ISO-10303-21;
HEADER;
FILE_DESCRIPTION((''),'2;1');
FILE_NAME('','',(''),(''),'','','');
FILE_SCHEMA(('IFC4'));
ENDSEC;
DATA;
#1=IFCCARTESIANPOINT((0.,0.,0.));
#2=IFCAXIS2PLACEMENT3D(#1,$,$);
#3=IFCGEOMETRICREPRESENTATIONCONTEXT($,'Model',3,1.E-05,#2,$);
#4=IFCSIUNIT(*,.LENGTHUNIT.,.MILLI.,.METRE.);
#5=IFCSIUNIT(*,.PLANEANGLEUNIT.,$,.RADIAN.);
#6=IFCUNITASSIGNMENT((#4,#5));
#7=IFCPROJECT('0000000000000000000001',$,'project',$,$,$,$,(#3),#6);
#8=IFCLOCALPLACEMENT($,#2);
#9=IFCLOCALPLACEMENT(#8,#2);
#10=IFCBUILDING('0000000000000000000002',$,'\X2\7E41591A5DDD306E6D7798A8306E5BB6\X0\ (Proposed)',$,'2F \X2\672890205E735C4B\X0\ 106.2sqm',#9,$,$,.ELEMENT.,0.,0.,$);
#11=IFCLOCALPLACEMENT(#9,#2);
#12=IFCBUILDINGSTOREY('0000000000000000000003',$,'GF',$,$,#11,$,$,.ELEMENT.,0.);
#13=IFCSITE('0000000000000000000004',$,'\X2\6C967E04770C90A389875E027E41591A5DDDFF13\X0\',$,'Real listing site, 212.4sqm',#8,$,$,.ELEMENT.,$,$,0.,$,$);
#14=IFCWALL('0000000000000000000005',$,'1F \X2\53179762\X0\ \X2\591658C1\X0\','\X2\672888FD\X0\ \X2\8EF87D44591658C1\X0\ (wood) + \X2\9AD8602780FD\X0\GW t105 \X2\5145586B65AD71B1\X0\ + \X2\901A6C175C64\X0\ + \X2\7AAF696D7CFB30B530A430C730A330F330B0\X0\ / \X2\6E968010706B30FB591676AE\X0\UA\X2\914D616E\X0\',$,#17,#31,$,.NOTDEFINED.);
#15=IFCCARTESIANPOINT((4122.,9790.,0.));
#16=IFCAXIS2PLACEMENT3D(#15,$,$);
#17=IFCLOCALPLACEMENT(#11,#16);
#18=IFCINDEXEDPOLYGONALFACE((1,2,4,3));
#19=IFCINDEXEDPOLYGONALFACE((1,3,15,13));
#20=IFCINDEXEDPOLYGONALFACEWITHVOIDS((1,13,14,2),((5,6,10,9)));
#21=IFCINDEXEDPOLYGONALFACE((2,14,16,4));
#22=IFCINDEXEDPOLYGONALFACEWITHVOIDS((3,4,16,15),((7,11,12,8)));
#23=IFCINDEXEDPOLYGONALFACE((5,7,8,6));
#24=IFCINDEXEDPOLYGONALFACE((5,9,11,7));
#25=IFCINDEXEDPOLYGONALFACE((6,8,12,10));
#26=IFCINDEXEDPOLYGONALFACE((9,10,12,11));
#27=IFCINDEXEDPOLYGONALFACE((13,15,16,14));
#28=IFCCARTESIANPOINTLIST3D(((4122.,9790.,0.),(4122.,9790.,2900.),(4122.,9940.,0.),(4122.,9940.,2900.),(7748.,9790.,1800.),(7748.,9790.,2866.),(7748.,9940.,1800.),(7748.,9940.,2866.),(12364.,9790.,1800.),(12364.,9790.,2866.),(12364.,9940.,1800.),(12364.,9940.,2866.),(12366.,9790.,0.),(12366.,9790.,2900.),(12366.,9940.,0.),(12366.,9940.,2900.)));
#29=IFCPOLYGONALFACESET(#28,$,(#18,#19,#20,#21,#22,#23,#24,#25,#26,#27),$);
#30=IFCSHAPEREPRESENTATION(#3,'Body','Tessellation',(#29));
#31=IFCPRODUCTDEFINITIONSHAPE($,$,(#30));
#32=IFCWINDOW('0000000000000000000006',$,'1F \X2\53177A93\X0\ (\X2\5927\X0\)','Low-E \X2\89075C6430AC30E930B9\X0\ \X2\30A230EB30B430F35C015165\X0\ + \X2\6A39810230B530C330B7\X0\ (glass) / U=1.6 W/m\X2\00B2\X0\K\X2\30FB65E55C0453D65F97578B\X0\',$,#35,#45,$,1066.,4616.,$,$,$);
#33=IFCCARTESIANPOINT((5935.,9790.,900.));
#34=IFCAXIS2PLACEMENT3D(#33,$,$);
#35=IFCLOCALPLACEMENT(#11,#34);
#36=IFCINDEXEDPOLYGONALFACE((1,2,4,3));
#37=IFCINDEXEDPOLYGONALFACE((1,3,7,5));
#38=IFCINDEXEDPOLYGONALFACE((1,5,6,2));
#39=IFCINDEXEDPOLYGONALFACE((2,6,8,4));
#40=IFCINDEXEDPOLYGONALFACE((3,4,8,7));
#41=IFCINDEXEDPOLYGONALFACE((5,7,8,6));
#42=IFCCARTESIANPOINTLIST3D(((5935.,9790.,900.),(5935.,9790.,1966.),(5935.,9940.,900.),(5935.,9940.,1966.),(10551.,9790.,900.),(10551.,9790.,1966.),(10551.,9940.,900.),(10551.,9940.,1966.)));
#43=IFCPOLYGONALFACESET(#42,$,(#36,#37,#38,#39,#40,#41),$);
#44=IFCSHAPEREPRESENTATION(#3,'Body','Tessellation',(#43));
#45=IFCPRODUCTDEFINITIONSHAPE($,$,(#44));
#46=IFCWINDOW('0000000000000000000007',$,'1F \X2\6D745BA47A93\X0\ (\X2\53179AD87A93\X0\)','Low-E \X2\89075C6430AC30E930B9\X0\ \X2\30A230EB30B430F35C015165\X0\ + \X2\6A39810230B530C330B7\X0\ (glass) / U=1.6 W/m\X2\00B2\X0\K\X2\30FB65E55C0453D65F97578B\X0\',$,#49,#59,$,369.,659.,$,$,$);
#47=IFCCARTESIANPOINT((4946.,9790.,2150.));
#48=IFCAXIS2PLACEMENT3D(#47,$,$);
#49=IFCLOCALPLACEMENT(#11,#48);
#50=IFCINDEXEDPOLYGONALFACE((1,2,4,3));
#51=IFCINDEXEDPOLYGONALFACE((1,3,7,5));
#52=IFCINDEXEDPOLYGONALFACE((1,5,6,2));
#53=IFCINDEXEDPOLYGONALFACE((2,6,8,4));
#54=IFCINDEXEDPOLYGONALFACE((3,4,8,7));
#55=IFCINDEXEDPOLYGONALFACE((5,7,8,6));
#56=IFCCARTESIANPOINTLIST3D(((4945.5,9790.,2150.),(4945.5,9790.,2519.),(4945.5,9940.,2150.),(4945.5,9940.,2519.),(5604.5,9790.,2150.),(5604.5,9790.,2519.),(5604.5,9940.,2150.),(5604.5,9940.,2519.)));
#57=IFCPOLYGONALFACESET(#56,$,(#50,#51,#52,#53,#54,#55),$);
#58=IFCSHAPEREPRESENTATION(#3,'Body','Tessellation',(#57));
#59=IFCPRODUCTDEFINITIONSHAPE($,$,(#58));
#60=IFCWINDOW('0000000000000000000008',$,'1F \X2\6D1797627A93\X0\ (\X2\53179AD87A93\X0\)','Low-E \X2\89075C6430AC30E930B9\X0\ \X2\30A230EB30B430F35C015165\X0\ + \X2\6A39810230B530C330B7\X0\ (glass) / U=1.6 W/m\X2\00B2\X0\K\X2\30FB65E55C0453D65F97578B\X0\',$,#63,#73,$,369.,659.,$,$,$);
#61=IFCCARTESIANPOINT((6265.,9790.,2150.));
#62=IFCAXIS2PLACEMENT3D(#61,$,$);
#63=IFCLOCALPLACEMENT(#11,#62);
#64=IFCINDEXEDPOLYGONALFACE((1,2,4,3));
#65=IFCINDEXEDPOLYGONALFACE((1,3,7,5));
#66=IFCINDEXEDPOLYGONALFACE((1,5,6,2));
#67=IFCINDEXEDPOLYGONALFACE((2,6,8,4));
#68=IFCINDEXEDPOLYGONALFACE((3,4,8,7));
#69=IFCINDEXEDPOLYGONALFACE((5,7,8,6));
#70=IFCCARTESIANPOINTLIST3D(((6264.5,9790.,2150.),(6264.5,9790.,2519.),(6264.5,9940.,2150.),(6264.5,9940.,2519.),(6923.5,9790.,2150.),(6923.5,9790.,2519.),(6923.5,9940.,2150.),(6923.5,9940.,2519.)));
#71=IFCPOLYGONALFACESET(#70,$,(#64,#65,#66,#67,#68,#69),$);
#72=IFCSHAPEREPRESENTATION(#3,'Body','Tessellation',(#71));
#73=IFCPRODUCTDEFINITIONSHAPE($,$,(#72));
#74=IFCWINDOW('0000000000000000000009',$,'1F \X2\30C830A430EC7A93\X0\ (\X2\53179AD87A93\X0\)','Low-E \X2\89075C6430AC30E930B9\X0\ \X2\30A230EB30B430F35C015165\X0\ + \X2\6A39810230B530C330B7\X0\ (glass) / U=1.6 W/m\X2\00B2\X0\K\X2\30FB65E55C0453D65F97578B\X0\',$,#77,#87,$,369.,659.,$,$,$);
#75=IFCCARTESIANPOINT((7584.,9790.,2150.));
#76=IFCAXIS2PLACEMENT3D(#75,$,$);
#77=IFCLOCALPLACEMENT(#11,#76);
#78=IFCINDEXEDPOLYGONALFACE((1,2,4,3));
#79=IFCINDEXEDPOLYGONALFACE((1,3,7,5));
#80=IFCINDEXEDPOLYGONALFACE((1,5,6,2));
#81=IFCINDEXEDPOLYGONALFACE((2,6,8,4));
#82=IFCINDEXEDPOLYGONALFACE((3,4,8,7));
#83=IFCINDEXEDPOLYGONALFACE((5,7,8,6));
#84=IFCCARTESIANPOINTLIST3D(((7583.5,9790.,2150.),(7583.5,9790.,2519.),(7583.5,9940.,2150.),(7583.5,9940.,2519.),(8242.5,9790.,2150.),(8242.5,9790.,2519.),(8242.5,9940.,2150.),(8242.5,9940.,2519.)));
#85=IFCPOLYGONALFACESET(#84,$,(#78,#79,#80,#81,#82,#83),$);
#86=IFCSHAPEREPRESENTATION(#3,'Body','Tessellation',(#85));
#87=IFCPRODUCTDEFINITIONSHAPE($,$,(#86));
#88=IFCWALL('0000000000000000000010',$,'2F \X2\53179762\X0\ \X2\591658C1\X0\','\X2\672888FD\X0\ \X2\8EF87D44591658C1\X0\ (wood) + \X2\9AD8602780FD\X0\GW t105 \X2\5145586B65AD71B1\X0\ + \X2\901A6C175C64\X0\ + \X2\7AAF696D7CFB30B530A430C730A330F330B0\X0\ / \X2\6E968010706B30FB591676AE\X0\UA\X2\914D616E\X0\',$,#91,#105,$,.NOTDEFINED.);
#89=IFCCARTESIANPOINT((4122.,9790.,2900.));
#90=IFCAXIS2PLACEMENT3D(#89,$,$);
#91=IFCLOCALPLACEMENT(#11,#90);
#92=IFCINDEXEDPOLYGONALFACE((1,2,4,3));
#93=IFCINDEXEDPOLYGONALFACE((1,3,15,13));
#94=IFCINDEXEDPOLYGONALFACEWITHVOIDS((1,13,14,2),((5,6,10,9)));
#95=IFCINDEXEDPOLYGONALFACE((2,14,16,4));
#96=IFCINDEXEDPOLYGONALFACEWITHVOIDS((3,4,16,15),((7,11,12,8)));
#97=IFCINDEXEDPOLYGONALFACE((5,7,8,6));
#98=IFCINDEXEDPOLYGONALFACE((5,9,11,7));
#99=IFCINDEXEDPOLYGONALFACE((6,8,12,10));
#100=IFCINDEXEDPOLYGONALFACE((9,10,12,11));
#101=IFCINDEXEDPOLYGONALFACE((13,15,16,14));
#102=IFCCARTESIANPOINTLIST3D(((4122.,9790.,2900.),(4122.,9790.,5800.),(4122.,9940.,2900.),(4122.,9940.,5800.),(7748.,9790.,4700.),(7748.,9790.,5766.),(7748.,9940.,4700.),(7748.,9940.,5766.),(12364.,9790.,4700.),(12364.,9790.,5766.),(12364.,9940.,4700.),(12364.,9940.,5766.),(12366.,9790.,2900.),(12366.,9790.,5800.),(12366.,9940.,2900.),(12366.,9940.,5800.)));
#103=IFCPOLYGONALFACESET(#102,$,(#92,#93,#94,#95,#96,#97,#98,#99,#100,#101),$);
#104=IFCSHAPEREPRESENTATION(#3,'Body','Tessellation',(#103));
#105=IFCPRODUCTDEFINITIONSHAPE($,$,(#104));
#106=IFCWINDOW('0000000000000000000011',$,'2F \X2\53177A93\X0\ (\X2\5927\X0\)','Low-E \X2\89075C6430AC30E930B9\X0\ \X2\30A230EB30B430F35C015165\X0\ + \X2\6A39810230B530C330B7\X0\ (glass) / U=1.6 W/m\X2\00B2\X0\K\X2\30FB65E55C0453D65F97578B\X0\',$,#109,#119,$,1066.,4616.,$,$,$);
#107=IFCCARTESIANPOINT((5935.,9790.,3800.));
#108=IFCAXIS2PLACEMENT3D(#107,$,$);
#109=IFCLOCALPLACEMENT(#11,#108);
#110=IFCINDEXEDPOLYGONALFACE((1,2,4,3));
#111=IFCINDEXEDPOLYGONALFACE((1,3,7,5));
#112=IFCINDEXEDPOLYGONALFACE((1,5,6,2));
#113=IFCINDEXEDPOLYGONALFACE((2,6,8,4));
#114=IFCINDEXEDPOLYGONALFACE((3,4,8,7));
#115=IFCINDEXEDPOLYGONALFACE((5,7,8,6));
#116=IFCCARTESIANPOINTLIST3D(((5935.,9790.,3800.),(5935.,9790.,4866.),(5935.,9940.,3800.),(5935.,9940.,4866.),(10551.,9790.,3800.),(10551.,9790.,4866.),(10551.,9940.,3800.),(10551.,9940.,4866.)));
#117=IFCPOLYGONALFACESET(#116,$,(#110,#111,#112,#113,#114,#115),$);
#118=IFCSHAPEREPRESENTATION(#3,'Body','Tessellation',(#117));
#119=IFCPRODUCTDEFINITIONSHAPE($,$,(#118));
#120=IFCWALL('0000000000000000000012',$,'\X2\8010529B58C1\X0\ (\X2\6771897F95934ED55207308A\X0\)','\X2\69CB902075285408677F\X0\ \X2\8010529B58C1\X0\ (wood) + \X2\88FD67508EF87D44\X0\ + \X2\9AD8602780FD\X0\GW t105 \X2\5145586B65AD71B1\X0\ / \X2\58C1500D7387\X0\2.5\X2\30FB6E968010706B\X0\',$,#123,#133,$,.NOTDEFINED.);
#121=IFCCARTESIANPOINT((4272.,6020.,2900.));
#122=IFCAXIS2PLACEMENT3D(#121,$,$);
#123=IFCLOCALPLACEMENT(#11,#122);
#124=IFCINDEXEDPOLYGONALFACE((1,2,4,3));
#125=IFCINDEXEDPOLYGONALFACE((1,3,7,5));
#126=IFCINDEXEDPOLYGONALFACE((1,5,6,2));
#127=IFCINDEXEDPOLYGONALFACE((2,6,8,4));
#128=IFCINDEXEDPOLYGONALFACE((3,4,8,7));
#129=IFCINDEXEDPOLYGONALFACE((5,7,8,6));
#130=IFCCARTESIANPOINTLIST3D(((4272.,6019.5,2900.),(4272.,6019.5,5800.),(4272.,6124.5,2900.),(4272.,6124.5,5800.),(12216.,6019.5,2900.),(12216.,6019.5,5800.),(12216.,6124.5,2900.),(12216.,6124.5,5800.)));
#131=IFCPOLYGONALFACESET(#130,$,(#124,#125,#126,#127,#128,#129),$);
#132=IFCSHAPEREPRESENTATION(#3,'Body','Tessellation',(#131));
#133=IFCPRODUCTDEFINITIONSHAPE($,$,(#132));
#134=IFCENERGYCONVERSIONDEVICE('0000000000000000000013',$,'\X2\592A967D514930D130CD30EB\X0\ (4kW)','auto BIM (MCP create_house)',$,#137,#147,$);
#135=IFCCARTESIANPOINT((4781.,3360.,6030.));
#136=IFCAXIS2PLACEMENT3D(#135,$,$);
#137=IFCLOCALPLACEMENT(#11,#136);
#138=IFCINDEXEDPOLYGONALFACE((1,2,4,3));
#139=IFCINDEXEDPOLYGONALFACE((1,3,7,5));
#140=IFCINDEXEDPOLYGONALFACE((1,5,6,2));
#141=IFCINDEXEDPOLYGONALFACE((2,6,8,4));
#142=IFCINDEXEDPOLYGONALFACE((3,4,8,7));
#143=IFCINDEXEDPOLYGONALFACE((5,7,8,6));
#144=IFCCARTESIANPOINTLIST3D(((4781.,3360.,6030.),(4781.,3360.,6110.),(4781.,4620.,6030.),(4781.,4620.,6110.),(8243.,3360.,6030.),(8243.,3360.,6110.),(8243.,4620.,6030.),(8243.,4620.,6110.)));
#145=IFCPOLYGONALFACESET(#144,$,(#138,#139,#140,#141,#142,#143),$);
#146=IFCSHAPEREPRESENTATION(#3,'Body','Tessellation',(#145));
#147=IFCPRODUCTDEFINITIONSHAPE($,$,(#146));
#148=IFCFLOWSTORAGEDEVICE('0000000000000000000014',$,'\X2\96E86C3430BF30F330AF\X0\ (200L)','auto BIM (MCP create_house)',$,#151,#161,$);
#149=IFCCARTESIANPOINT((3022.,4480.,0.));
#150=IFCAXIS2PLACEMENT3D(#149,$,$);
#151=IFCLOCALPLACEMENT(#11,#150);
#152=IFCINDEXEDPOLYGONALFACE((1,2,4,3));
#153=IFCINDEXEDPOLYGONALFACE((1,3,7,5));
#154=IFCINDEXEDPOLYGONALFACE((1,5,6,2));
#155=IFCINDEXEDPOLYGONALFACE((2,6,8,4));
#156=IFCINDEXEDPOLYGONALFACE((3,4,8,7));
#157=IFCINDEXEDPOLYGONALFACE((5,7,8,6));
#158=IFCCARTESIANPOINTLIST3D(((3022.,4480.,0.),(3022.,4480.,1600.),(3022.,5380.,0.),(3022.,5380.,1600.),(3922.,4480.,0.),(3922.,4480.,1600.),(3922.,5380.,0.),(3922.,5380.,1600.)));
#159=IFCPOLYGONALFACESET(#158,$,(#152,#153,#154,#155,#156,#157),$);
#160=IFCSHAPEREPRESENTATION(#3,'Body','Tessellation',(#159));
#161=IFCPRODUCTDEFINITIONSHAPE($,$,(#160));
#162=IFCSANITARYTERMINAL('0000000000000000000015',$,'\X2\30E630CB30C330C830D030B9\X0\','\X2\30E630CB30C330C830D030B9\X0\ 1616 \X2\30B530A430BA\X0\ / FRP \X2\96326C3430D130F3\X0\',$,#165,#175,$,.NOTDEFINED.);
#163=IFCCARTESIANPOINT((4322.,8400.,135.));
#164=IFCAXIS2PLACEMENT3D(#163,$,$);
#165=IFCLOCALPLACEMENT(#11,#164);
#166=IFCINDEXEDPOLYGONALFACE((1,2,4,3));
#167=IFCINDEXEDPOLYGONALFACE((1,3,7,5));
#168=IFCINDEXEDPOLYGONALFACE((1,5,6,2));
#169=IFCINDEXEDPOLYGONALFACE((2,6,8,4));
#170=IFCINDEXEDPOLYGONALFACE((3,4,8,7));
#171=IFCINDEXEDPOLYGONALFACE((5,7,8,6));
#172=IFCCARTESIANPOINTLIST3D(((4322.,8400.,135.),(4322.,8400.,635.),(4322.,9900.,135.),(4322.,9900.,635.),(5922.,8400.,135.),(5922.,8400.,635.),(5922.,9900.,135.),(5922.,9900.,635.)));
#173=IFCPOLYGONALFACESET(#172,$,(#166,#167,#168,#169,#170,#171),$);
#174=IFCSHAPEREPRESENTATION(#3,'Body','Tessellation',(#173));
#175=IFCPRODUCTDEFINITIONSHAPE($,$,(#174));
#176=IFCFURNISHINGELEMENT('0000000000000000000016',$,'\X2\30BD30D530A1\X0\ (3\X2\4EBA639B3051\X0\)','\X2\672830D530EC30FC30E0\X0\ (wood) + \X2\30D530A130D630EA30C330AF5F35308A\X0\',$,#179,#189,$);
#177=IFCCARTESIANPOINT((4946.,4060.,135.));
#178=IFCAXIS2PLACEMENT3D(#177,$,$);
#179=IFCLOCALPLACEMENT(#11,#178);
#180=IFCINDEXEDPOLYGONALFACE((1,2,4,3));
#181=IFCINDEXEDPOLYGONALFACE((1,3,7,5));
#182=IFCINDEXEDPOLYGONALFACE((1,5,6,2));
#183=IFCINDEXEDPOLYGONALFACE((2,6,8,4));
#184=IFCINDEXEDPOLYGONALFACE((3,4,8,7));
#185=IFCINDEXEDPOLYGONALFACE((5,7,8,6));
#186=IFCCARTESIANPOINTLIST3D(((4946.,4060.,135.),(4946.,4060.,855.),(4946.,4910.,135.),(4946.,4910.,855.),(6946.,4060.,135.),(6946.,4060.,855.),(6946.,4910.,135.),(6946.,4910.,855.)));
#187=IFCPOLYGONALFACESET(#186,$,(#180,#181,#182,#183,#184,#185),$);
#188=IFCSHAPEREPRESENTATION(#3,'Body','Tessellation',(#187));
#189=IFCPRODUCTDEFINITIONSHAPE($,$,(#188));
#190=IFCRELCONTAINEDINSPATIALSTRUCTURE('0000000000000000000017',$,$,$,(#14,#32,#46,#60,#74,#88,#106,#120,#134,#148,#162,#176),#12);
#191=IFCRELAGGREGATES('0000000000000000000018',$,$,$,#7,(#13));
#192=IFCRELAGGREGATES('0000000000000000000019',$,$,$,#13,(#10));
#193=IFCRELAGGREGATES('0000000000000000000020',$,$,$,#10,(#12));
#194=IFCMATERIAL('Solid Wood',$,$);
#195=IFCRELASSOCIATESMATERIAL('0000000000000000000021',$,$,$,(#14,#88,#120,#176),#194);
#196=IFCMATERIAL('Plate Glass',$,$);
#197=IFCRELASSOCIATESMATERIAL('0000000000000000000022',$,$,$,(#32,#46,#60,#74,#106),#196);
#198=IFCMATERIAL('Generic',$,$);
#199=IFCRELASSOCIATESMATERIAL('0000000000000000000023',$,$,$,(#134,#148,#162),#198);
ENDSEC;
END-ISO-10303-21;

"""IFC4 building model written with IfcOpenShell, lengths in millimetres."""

from ifc_helpers import new_model, si_unit, frame, frame_2d, origin, place, context, project, spatial, rectangle, extrude, material, element, fill, save


model = new_model("IFC4")

# Units and contexts
model_context = context("Model", 3, precision=1e-05, world=origin())
ifc_project = project(units=[si_unit("LENGTHUNIT", "METRE", prefix="MILLI"), si_unit("PLANEANGLEUNIT", "RADIAN")], contexts=[model_context])

# Site, building, storey
site_placement = place(None, origin())
site = spatial("IfcSite", under=ifc_project, at=site_placement, Name="沖縄県那覇市繁多川３", ObjectType="Real listing site, 212.4sqm", CompositionType="ELEMENT", RefElevation=0.0)
building_placement = place(site_placement, origin())
building = spatial("IfcBuilding", under=site, at=building_placement, Name="繁多川の海風の家 (Proposed)", ObjectType="2F 木造平屋 106.2sqm", CompositionType="ELEMENT", ElevationOfRefHeight=0.0, ElevationOfTerrain=0.0)
storey_placement = place(building_placement, origin())
storey = spatial("IfcBuildingStorey", under=building, at=storey_placement, Name="GF", CompositionType="ELEMENT", Elevation=0.0)

# Wall, openings, windows
ifc_material_1 = material(Name="Solid Wood")
wall_1_placement = place(storey_placement, frame((4122.0, 9790.0, 0.0)))
wall_1 = element("IfcWall", 1, at=wall_1_placement, inside=storey, material=ifc_material_1, Name="1F 北面 外壁", Description="木製 軸組外壁 (wood) + 高性能GW t105 充填断熱 + 通気層 + 窯業系サイディング / 準耐火・外皮UA配慮", PredefinedType="NOTDEFINED", context=model_context, shape_type="SweptSolid", body=[
    extrude(rectangle(XDim=8244.0, YDim=150.0, at=frame_2d((4122.0, 75.0))), frame((4122.0, 9790.0, 0.0)), (0.0, 0.0, 1.0), 2900.0),
])
opening_1_placement = place(storey_placement, frame((5935.0, 9790.0, 900.0)))
opening_1 = element("IfcOpeningElement", 2, at=opening_1_placement, cuts=wall_1, PredefinedType="NOTDEFINED", context=model_context, shape_type="SweptSolid", body=[
    extrude(rectangle(XDim=4616.0, YDim=150.0, at=frame_2d((2308.0, 75.0))), frame((5935.0, 9790.0, 900.0)), (0.0, 0.0, 1.0), 1066.0),
])
opening_2_placement = place(storey_placement, frame((4946.0, 9790.0, 2150.0)))
opening_2 = element("IfcOpeningElement", 3, at=opening_2_placement, cuts=wall_1, PredefinedType="NOTDEFINED", context=model_context, shape_type="SweptSolid", body=[
    extrude(rectangle(XDim=659.0, YDim=150.0, at=frame_2d((329.0, 75.0))), frame((4946.0, 9790.0, 2150.0)), (0.0, 0.0, 1.0), 369.0),
])
opening_3_placement = place(storey_placement, frame((6265.0, 9790.0, 2150.0)))
opening_3 = element("IfcOpeningElement", 4, at=opening_3_placement, cuts=wall_1, PredefinedType="NOTDEFINED", context=model_context, shape_type="SweptSolid", body=[
    extrude(rectangle(XDim=659.0, YDim=150.0, at=frame_2d((329.0, 75.0))), frame((6265.0, 9790.0, 2150.0)), (0.0, 0.0, 1.0), 369.0),
])
opening_4_placement = place(storey_placement, frame((7584.0, 9790.0, 2150.0)))
opening_4 = element("IfcOpeningElement", 5, at=opening_4_placement, cuts=wall_1, PredefinedType="NOTDEFINED", context=model_context, shape_type="SweptSolid", body=[
    extrude(rectangle(XDim=659.0, YDim=150.0, at=frame_2d((329.0, 75.0))), frame((7584.0, 9790.0, 2150.0)), (0.0, 0.0, 1.0), 369.0),
])
ifc_material_2 = material(Name="Plate Glass")
window_1_placement = place(storey_placement, frame((5935.0, 9790.0, 900.0)))
window_1 = element("IfcWindow", 6, at=window_1_placement, inside=storey, material=ifc_material_2, Name="1F 北窓 (大)", Description="Low-E 複層ガラス アルゴン封入 + 樹脂サッシ (glass) / U=1.6 W/m²K・日射取得型", OverallHeight=1066.0, OverallWidth=4616.0, context=model_context, shape_type="SweptSolid", body=[
    extrude(rectangle(XDim=4616.0, YDim=150.0, at=frame_2d((2308.0, 75.0))), frame((5935.0, 9790.0, 900.0)), (0.0, 0.0, 1.0), 1066.0),
])
fill(opening_1, window_1)
window_2_placement = place(storey_placement, frame((4946.0, 9790.0, 2150.0)))
window_2 = element("IfcWindow", 7, at=window_2_placement, inside=storey, material=ifc_material_2, Name="1F 浴室窓 (北高窓)", Description="Low-E 複層ガラス アルゴン封入 + 樹脂サッシ (glass) / U=1.6 W/m²K・日射取得型", OverallHeight=369.0, OverallWidth=659.0, context=model_context, shape_type="SweptSolid", body=[
    extrude(rectangle(XDim=659.0, YDim=150.0, at=frame_2d((329.0, 75.0))), frame((4946.0, 9790.0, 2150.0)), (0.0, 0.0, 1.0), 369.0),
])
fill(opening_2, window_2)
window_3_placement = place(storey_placement, frame((6265.0, 9790.0, 2150.0)))
window_3 = element("IfcWindow", 8, at=window_3_placement, inside=storey, material=ifc_material_2, Name="1F 洗面窓 (北高窓)", Description="Low-E 複層ガラス アルゴン封入 + 樹脂サッシ (glass) / U=1.6 W/m²K・日射取得型", OverallHeight=369.0, OverallWidth=659.0, context=model_context, shape_type="SweptSolid", body=[
    extrude(rectangle(XDim=659.0, YDim=150.0, at=frame_2d((329.0, 75.0))), frame((6265.0, 9790.0, 2150.0)), (0.0, 0.0, 1.0), 369.0),
])
fill(opening_3, window_3)
window_4_placement = place(storey_placement, frame((7584.0, 9790.0, 2150.0)))
window_4 = element("IfcWindow", 9, at=window_4_placement, inside=storey, material=ifc_material_2, Name="1F トイレ窓 (北高窓)", Description="Low-E 複層ガラス アルゴン封入 + 樹脂サッシ (glass) / U=1.6 W/m²K・日射取得型", OverallHeight=369.0, OverallWidth=659.0, context=model_context, shape_type="SweptSolid", body=[
    extrude(rectangle(XDim=659.0, YDim=150.0, at=frame_2d((329.0, 75.0))), frame((7584.0, 9790.0, 2150.0)), (0.0, 0.0, 1.0), 369.0),
])
fill(opening_4, window_4)

# Wall, opening, window
wall_2_placement = place(storey_placement, frame((4122.0, 9790.0, 2900.0)))
wall_2 = element("IfcWall", 10, at=wall_2_placement, inside=storey, material=ifc_material_1, Name="2F 北面 外壁", Description="木製 軸組外壁 (wood) + 高性能GW t105 充填断熱 + 通気層 + 窯業系サイディング / 準耐火・外皮UA配慮", PredefinedType="NOTDEFINED", context=model_context, shape_type="SweptSolid", body=[
    extrude(rectangle(XDim=8244.0, YDim=150.0, at=frame_2d((4122.0, 75.0))), frame((4122.0, 9790.0, 2900.0)), (0.0, 0.0, 1.0), 2900.0),
])
opening_5_placement = place(storey_placement, frame((5935.0, 9790.0, 3800.0)))
opening_5 = element("IfcOpeningElement", 11, at=opening_5_placement, cuts=wall_2, PredefinedType="NOTDEFINED", context=model_context, shape_type="SweptSolid", body=[
    extrude(rectangle(XDim=4616.0, YDim=150.0, at=frame_2d((2308.0, 75.0))), frame((5935.0, 9790.0, 3800.0)), (0.0, 0.0, 1.0), 1066.0),
])
window_5_placement = place(storey_placement, frame((5935.0, 9790.0, 3800.0)))
window_5 = element("IfcWindow", 12, at=window_5_placement, inside=storey, material=ifc_material_2, Name="2F 北窓 (大)", Description="Low-E 複層ガラス アルゴン封入 + 樹脂サッシ (glass) / U=1.6 W/m²K・日射取得型", OverallHeight=1066.0, OverallWidth=4616.0, context=model_context, shape_type="SweptSolid", body=[
    extrude(rectangle(XDim=4616.0, YDim=150.0, at=frame_2d((2308.0, 75.0))), frame((5935.0, 9790.0, 3800.0)), (0.0, 0.0, 1.0), 1066.0),
])
fill(opening_5, window_5)

# Wall
wall_3_placement = place(storey_placement, frame((4272.0, 6020.0, 2900.0)))
element("IfcWall", 13, at=wall_3_placement, inside=storey, material=ifc_material_1, Name="耐力壁 (東西間仕切り)", Description="構造用合板 耐力壁 (wood) + 製材軸組 + 高性能GW t105 充填断熱 / 壁倍率2.5・準耐火", PredefinedType="NOTDEFINED", context=model_context, shape_type="SweptSolid", body=[
    extrude(rectangle(XDim=7944.0, YDim=105.0, at=frame_2d((3972.0, 52.0))), frame((4272.0, 6020.0, 2900.0)), (0.0, 0.0, 1.0), 2900.0),
])

# Energy conversion device
ifc_material_3 = material(Name="Generic")
energy_conversion_device_placement = place(storey_placement, frame((4781.0, 3360.0, 6030.0)))
element("IfcEnergyConversionDevice", 14, at=energy_conversion_device_placement, inside=storey, material=ifc_material_3, Name="太陽光パネル (4kW)", Description="auto BIM (MCP create_house)", context=model_context, shape_type="SweptSolid", body=[
    extrude(rectangle(XDim=3462.0, YDim=1260.0, at=frame_2d((1731.0, 630.0))), frame((4781.0, 3360.0, 6030.0)), (0.0, 0.0, 1.0), 80.0),
])

# Flow storage device
flow_storage_device_placement = place(storey_placement, frame((3022.0, 4480.0, 0.0)))
element("IfcFlowStorageDevice", 15, at=flow_storage_device_placement, inside=storey, material=ifc_material_3, Name="雨水タンク (200L)", Description="auto BIM (MCP create_house)", context=model_context, shape_type="SweptSolid", body=[
    extrude(rectangle(XDim=900.0, YDim=900.0, at=frame_2d((450.0, 450.0))), frame((3022.0, 4480.0, 0.0)), (0.0, 0.0, 1.0), 1600.0),
])

# Sanitary terminal
sanitary_terminal_placement = place(storey_placement, frame((4322.0, 8400.0, 135.0)))
element("IfcSanitaryTerminal", 16, at=sanitary_terminal_placement, inside=storey, material=ifc_material_3, Name="ユニットバス", Description="ユニットバス 1616 サイズ / FRP 防水パン", PredefinedType="NOTDEFINED", context=model_context, shape_type="SweptSolid", body=[
    extrude(rectangle(XDim=1600.0, YDim=1500.0, at=frame_2d((800.0, 750.0))), frame((4322.0, 8400.0, 135.0)), (0.0, 0.0, 1.0), 500.0),
])

# Furnishing element
furnishing_1_placement = place(storey_placement, frame((4946.0, 4060.0, 135.0)))
element("IfcFurnishingElement", 17, at=furnishing_1_placement, inside=storey, material=ifc_material_1, Name="ソファ (3人掛け)", Description="木フレーム (wood) + ファブリック張り", context=model_context, shape_type="SweptSolid", body=[
    extrude(rectangle(XDim=2000.0, YDim=850.0, at=frame_2d((1000.0, 425.0))), frame((4946.0, 4060.0, 135.0)), (0.0, 0.0, 1.0), 720.0),
])

save(model, "model.ifc")
